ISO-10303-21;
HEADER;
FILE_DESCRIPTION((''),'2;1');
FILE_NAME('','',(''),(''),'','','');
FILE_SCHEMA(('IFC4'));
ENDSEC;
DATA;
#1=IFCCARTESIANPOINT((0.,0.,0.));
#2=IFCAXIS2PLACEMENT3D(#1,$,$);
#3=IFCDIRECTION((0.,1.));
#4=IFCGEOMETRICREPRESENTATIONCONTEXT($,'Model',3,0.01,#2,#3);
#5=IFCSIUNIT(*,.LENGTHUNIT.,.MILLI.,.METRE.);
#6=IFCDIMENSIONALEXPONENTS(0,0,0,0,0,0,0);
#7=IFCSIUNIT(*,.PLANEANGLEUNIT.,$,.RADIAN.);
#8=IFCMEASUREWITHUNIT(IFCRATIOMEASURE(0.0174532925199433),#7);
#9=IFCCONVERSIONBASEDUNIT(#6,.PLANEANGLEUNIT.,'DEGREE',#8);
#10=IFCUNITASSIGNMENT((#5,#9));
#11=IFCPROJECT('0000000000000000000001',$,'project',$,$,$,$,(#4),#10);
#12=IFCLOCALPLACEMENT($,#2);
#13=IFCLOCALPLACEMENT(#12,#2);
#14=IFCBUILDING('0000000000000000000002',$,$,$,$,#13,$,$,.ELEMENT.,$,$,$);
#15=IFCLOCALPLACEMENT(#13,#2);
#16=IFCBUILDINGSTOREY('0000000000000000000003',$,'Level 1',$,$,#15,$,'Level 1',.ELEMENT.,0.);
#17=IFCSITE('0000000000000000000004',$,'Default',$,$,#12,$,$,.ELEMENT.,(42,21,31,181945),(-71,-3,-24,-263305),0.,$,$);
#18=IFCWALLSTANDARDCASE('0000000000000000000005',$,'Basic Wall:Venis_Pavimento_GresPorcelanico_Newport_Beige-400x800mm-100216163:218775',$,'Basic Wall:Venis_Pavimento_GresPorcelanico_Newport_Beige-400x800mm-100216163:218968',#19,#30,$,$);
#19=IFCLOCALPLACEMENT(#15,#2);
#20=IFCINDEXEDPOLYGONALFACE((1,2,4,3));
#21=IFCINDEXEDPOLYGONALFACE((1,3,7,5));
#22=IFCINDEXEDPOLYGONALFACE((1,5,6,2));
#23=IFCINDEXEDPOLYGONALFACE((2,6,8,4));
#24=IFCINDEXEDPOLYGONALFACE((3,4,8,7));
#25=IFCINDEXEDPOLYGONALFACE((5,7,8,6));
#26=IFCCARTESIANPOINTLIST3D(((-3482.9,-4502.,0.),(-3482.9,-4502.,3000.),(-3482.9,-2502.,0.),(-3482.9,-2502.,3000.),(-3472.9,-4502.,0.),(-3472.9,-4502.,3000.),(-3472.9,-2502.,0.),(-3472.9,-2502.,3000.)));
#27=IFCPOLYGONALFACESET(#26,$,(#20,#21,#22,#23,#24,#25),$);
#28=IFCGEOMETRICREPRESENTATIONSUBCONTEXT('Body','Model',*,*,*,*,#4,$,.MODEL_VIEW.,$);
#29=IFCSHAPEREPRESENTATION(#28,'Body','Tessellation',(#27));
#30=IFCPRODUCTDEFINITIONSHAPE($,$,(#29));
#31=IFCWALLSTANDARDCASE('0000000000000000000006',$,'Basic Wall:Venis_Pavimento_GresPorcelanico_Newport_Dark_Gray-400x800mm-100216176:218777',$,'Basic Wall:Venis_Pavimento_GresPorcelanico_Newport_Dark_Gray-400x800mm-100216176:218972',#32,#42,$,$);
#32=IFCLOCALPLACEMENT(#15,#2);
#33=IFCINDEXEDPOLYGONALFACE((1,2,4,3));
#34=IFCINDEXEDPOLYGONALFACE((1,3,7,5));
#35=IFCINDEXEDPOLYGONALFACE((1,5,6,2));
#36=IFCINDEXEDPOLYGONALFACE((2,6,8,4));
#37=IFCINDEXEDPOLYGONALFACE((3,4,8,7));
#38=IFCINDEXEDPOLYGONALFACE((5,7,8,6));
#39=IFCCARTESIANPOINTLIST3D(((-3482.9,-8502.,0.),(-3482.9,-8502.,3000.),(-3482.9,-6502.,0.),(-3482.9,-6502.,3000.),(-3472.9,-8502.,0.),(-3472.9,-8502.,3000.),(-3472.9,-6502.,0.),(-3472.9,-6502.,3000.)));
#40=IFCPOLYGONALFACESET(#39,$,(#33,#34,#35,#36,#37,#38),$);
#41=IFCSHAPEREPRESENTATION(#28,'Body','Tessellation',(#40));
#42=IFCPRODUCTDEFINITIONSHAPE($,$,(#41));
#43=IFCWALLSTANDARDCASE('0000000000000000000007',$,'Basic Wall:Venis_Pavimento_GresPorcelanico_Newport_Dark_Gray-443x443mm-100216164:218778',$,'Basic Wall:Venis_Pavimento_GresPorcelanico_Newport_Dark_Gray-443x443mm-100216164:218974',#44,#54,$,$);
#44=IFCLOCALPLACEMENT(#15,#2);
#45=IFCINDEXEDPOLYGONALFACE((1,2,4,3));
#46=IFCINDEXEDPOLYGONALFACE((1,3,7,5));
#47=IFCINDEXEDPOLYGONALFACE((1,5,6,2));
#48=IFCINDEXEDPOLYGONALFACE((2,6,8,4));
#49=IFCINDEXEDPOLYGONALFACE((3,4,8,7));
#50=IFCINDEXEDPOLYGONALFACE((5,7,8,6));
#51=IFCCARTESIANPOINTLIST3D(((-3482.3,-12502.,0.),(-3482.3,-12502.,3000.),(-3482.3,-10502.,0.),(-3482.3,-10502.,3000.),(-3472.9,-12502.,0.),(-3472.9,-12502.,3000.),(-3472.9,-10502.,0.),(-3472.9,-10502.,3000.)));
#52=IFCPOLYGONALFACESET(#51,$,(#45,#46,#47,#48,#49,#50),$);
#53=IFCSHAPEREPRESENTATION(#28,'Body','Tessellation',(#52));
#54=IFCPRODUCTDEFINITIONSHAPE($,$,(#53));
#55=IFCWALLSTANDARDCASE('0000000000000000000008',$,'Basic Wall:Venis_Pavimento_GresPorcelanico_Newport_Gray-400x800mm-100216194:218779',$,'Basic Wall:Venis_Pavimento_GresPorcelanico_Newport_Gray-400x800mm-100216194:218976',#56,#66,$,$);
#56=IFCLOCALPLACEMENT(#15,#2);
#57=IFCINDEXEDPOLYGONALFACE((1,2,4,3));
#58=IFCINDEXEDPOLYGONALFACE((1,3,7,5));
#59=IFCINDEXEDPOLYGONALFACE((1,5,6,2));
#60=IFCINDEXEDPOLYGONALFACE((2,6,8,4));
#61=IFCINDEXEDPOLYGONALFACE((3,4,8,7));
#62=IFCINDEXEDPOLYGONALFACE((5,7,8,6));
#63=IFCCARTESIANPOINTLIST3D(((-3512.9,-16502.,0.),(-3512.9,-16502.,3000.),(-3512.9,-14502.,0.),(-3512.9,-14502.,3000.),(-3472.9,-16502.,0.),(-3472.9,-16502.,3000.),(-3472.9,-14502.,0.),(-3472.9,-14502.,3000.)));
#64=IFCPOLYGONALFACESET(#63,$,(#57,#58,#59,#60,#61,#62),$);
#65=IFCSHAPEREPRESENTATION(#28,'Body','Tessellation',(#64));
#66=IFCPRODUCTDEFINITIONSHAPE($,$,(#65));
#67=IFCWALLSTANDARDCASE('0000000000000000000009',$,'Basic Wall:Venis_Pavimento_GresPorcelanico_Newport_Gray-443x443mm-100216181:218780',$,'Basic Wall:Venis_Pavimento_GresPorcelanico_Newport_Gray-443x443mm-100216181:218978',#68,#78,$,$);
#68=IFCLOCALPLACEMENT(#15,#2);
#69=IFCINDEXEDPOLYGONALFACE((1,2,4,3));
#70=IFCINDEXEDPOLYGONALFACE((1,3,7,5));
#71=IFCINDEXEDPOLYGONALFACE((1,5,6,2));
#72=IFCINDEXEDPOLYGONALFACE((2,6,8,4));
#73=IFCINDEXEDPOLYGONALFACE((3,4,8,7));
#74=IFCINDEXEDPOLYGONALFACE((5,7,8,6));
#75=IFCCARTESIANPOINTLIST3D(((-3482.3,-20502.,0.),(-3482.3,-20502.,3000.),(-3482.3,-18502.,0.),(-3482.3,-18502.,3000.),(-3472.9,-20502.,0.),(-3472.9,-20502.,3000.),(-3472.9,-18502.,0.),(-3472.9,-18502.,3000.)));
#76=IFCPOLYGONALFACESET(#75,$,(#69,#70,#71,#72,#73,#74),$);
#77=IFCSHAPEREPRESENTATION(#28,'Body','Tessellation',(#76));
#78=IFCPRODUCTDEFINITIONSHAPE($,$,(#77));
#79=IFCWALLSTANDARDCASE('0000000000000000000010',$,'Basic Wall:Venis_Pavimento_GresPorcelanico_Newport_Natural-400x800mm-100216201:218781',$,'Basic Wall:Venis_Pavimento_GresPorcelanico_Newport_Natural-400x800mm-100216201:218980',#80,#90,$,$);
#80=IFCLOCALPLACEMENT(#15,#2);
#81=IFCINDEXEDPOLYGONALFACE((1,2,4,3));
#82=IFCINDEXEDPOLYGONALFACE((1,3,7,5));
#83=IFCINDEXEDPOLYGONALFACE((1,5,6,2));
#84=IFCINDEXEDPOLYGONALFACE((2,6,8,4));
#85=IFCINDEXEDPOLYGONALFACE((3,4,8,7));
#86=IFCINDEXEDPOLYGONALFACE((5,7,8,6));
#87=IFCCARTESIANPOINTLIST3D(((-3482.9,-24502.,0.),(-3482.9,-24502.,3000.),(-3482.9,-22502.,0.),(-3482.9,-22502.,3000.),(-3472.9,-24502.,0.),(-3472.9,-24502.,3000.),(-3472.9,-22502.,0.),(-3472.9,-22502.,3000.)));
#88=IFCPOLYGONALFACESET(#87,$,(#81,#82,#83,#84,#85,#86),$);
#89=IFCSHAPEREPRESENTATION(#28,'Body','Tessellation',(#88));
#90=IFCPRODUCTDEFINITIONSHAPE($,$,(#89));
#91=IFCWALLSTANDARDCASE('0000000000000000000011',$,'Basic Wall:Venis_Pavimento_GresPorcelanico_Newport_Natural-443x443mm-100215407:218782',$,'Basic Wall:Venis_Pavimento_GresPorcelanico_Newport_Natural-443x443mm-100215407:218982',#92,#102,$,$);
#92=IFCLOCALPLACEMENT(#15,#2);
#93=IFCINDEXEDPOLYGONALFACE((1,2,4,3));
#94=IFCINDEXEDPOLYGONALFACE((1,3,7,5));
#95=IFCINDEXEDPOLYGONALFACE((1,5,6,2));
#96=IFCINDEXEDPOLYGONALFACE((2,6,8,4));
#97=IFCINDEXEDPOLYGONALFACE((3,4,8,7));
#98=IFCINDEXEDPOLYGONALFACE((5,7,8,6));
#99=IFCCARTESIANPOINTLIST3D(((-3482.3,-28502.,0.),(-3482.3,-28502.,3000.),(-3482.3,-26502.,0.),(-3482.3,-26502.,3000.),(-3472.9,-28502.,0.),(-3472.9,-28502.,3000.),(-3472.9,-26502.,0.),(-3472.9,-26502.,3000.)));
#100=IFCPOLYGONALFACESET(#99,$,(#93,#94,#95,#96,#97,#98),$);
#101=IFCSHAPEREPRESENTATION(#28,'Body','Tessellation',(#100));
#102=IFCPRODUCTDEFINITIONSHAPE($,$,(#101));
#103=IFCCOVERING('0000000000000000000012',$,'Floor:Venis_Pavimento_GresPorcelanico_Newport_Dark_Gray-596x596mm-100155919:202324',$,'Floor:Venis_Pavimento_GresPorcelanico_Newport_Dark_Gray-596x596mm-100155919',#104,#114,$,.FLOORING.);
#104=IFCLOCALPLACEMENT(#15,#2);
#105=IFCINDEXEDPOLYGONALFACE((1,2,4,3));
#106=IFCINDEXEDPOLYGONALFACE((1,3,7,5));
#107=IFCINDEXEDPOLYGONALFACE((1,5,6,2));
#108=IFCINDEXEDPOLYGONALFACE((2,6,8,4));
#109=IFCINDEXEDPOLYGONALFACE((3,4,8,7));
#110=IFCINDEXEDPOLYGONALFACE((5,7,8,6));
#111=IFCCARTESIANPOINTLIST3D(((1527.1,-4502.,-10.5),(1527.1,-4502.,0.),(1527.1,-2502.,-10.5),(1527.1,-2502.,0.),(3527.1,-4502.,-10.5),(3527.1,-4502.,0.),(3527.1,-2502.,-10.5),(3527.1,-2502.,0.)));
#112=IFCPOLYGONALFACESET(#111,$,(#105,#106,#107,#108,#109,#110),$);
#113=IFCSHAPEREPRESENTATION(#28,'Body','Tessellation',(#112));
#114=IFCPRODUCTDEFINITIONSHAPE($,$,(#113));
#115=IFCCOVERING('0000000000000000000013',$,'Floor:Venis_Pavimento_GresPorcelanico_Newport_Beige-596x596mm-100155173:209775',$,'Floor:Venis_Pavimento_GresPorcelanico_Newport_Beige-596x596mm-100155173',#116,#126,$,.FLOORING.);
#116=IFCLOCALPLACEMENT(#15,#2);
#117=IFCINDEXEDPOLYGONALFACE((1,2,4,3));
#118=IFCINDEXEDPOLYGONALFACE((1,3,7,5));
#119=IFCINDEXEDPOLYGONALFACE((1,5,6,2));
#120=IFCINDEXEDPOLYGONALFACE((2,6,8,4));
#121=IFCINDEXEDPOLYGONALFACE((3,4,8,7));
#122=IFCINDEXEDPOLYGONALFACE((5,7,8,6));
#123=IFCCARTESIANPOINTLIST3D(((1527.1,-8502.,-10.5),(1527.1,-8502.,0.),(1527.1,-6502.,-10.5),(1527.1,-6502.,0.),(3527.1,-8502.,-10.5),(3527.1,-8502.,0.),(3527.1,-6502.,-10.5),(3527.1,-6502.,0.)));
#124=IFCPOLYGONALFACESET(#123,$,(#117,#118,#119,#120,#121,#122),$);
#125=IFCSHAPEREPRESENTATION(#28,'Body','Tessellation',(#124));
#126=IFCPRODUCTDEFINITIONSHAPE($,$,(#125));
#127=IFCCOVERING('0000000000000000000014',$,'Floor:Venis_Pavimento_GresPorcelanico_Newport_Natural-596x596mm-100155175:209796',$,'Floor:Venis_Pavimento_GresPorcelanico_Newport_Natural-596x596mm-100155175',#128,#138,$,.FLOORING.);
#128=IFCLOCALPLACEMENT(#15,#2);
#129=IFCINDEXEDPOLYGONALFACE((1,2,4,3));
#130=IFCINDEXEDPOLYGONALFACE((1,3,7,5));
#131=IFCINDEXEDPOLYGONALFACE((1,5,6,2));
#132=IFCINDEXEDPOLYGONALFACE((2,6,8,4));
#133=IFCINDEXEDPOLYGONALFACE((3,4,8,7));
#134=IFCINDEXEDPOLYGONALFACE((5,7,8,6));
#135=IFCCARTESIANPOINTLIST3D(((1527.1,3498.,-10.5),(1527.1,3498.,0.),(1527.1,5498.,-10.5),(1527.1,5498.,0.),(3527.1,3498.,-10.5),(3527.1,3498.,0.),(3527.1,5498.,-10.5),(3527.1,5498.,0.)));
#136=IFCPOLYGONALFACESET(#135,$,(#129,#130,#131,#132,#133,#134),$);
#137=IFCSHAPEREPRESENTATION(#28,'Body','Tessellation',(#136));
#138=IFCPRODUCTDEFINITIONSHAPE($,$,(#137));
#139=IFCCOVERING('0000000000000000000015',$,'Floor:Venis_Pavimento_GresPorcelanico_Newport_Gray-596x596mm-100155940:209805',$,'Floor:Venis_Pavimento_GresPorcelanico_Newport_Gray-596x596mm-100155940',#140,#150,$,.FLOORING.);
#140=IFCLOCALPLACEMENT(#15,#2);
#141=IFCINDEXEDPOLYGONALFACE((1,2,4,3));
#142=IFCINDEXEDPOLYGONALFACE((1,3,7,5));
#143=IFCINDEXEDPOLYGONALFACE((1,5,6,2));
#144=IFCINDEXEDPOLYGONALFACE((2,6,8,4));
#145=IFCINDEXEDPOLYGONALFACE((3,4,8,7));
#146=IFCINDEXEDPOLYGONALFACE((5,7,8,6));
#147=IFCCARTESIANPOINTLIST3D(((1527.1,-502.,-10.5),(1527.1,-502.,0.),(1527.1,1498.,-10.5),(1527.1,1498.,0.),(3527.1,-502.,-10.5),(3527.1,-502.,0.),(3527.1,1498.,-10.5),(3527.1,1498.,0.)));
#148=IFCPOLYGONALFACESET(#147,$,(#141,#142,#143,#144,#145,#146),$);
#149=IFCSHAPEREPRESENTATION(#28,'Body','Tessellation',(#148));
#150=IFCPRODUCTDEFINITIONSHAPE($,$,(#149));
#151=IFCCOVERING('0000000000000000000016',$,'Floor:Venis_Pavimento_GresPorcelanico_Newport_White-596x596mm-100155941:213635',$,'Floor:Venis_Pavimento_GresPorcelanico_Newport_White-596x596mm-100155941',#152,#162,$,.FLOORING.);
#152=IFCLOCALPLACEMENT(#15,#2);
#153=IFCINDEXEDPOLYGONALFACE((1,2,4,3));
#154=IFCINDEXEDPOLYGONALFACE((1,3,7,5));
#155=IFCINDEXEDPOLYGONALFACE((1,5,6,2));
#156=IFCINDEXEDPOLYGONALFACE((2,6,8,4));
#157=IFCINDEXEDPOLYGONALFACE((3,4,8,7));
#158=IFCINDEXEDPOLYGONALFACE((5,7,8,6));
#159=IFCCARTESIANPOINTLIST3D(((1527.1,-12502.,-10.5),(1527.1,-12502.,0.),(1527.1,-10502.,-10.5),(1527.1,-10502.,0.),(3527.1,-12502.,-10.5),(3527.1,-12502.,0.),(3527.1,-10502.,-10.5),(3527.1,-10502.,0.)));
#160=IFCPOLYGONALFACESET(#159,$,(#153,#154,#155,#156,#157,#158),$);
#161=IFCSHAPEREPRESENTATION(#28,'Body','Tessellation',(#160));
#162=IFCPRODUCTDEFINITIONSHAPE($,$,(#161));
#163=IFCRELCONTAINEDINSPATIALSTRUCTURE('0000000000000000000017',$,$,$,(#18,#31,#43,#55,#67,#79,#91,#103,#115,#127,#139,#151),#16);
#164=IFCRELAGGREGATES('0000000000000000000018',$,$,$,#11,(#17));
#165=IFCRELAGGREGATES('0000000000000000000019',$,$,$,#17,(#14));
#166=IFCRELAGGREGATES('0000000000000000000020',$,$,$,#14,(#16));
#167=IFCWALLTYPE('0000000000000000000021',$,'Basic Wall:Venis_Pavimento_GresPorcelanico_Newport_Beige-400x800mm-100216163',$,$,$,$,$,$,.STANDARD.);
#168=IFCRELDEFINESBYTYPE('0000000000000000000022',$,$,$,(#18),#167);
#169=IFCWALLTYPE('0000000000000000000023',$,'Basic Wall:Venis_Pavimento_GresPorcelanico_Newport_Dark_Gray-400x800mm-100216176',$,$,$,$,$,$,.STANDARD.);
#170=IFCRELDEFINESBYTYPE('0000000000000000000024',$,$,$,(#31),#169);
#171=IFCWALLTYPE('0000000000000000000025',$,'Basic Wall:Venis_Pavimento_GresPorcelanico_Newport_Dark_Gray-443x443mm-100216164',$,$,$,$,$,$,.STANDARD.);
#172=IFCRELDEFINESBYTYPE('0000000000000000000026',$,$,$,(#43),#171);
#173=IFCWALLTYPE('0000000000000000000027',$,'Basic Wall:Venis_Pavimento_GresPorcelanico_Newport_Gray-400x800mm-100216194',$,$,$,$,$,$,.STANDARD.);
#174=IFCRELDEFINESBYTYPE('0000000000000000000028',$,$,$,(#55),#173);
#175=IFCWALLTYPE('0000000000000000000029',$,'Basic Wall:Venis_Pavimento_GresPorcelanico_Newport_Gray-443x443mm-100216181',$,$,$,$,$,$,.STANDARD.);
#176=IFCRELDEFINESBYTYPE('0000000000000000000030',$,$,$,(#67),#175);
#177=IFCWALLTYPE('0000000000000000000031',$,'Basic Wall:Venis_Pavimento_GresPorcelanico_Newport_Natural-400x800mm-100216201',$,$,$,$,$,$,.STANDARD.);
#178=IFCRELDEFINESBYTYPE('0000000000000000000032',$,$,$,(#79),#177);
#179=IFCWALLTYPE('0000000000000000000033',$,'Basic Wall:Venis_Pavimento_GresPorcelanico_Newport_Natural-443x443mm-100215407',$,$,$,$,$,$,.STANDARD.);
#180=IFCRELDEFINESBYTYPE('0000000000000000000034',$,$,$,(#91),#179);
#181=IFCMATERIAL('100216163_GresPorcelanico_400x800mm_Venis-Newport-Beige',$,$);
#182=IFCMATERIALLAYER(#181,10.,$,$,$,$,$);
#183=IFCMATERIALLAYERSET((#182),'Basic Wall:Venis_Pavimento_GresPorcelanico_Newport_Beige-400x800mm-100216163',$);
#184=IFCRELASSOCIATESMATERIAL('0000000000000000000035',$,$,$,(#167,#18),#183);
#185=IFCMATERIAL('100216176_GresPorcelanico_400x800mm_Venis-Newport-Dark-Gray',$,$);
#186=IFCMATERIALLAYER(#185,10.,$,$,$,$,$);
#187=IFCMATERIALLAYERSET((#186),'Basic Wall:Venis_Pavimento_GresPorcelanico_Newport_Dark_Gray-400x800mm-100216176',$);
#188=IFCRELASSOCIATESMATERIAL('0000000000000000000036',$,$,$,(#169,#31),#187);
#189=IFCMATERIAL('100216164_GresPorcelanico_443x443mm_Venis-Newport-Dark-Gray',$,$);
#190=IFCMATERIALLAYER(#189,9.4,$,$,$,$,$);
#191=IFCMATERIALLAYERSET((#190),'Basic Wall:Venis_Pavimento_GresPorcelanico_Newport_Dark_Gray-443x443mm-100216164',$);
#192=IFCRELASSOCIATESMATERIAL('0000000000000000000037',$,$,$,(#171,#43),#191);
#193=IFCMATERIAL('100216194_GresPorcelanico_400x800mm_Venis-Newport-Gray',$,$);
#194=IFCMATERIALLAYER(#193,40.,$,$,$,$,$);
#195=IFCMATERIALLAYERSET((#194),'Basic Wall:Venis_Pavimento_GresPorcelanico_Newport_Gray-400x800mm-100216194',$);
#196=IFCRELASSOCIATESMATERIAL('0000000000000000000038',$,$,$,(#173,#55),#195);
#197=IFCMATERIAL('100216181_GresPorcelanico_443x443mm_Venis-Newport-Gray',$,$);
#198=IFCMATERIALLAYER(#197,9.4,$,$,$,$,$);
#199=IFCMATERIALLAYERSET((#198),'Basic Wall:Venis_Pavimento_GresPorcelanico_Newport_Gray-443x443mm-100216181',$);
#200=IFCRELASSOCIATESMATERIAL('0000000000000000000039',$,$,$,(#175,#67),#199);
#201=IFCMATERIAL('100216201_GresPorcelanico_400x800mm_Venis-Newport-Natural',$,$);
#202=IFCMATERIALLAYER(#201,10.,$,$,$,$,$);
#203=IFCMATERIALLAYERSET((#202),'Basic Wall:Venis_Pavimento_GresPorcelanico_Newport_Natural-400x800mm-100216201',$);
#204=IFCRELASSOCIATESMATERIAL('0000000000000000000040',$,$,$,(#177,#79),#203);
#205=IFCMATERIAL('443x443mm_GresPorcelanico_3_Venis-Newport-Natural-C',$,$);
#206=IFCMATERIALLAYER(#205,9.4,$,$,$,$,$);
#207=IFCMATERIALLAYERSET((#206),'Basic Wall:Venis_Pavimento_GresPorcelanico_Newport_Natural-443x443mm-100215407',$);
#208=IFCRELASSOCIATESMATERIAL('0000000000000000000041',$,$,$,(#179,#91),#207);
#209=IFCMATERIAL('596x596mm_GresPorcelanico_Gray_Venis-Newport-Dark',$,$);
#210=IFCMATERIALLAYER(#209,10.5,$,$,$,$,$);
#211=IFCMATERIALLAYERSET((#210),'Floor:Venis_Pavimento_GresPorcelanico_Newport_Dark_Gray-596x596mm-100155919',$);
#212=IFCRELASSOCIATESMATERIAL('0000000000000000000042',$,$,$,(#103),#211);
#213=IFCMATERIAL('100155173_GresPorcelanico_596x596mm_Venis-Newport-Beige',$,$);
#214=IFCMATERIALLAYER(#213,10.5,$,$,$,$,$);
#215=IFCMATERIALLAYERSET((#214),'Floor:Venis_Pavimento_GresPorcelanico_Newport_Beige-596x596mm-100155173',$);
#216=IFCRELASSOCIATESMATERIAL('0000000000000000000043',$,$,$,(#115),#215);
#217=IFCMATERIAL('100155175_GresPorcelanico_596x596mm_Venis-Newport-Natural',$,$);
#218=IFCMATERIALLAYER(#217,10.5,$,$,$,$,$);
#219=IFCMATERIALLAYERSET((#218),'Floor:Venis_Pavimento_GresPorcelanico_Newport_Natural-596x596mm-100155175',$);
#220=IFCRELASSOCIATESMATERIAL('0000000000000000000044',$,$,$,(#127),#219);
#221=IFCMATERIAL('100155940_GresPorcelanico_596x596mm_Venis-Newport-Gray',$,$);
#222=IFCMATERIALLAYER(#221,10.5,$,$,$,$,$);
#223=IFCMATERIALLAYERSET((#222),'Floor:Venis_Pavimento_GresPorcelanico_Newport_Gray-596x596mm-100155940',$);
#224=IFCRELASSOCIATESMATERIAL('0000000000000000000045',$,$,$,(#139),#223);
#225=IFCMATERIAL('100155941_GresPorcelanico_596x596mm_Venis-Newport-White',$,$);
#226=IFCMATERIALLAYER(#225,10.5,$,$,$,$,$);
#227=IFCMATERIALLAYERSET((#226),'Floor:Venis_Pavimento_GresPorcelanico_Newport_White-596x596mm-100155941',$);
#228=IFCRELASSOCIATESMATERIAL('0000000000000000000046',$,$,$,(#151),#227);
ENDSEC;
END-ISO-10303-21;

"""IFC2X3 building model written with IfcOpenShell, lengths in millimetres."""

from ifc_helpers import new_model, entity, si_unit, converted_unit, direction, frame, frame_2d, origin, place, context, subcontext, project, spatial, rectangle, extrude, material, layer, layer_set, layer_usage, type_object, element, save


model = new_model("IFC2X3")

# Units and contexts
model_context = context("Model", 3, precision=0.01, world=origin(), true_north=direction((0.0, 1.0)))
body_context = subcontext(model_context, "Body", "Model", "MODEL_VIEW")
ifc_project = project(units=[si_unit("LENGTHUNIT", "METRE", prefix="MILLI"), converted_unit("PLANEANGLEUNIT", "DEGREE", entity("IfcRatioMeasure", 0.0174532925199433), si_unit("PLANEANGLEUNIT", "RADIAN"), dimensions=[0, 0, 0, 0, 0, 0, 0])], contexts=[model_context])

# Site, building, storey
site_placement = place(None, origin())
site = spatial("IfcSite", under=ifc_project, at=site_placement, Name="Default", CompositionType="ELEMENT", RefLatitude=(42, 21, 31, 181945), RefLongitude=(-71, -3, -24, -263305), RefElevation=0.0)
building_placement = place(site_placement, origin())
building = spatial("IfcBuilding", under=site, at=building_placement, CompositionType="ELEMENT")
storey_placement = place(building_placement, origin())
storey = spatial("IfcBuildingStorey", under=building, at=storey_placement, Name="Level 1", LongName="Level 1", CompositionType="ELEMENT", Elevation=0.0)

# Walls
ifc_material_1 = material(Name="596x596mm_GresPorcelanico_Gray_Venis-Newport-Dark")
ifc_material_2 = material(Name="100155173_GresPorcelanico_596x596mm_Venis-Newport-Beige")
ifc_material_3 = material(Name="100155941_GresPorcelanico_596x596mm_Venis-Newport-White")
ifc_material_4 = material(Name="100216163_GresPorcelanico_400x800mm_Venis-Newport-Beige")
ifc_layer_1 = layer(ifc_material_4, 10.0)
ifc_layer_set_1 = layer_set([ifc_layer_1], Name="Basic Wall:Venis_Pavimento_GresPorcelanico_Newport_Beige-400x800mm-100216163")
ifc_layer_usage_1 = layer_usage(ifc_layer_set_1, "AXIS2", "POSITIVE", -5.0)
wall_type_1 = type_object("IfcWallType", Name="Basic Wall:Venis_Pavimento_GresPorcelanico_Newport_Beige-400x800mm-100216163", PredefinedType="STANDARD", material=ifc_layer_set_1)
wall_1_placement = place(storey_placement, frame((-3477.9, -2502.0, 0.0), z_axis=(0.0, 0.0, 1.0), x_axis=(0.0, -1.0, 0.0)))
element("IfcWallStandardCase", 1, at=wall_1_placement, inside=storey, type_object=wall_type_1, material=ifc_layer_usage_1, Name="Basic Wall:Venis_Pavimento_GresPorcelanico_Newport_Beige-400x800mm-100216163:218775", ObjectType="Basic Wall:Venis_Pavimento_GresPorcelanico_Newport_Beige-400x800mm-100216163:218968", context=body_context, shape_type="SweptSolid", body=[
    extrude(rectangle(XDim=2000.0, YDim=10.0, at=frame_2d((1000.0, 0.0), x_axis=(-1.0, 0.0))), origin(), (0.0, 0.0, 1.0), 3000.0),
])
ifc_material_5 = material(Name="100216176_GresPorcelanico_400x800mm_Venis-Newport-Dark-Gray")
ifc_layer_2 = layer(ifc_material_5, 10.0)
ifc_layer_set_2 = layer_set([ifc_layer_2], Name="Basic Wall:Venis_Pavimento_GresPorcelanico_Newport_Dark_Gray-400x800mm-100216176")
ifc_layer_usage_2 = layer_usage(ifc_layer_set_2, "AXIS2", "POSITIVE", -5.0)
wall_type_2 = type_object("IfcWallType", Name="Basic Wall:Venis_Pavimento_GresPorcelanico_Newport_Dark_Gray-400x800mm-100216176", PredefinedType="STANDARD", material=ifc_layer_set_2)
wall_2_placement = place(storey_placement, frame((-3477.9, -6502.0, 0.0), z_axis=(0.0, 0.0, 1.0), x_axis=(0.0, -1.0, 0.0)))
element("IfcWallStandardCase", 2, at=wall_2_placement, inside=storey, type_object=wall_type_2, material=ifc_layer_usage_2, Name="Basic Wall:Venis_Pavimento_GresPorcelanico_Newport_Dark_Gray-400x800mm-100216176:218777", ObjectType="Basic Wall:Venis_Pavimento_GresPorcelanico_Newport_Dark_Gray-400x800mm-100216176:218972", context=body_context, shape_type="SweptSolid", body=[
    extrude(rectangle(XDim=2000.0, YDim=10.0, at=frame_2d((1000.0, 0.0), x_axis=(-1.0, 0.0))), origin(), (0.0, 0.0, 1.0), 3000.0),
])
ifc_material_6 = material(Name="100216164_GresPorcelanico_443x443mm_Venis-Newport-Dark-Gray")
ifc_layer_3 = layer(ifc_material_6, 9.4)
ifc_layer_set_3 = layer_set([ifc_layer_3], Name="Basic Wall:Venis_Pavimento_GresPorcelanico_Newport_Dark_Gray-443x443mm-100216164")
ifc_layer_usage_3 = layer_usage(ifc_layer_set_3, "AXIS2", "POSITIVE", -4.7)
wall_type_3 = type_object("IfcWallType", Name="Basic Wall:Venis_Pavimento_GresPorcelanico_Newport_Dark_Gray-443x443mm-100216164", PredefinedType="STANDARD", material=ifc_layer_set_3)
wall_3_placement = place(storey_placement, frame((-3477.6, -10502.0, 0.0), z_axis=(0.0, 0.0, 1.0), x_axis=(0.0, -1.0, 0.0)))
element("IfcWallStandardCase", 3, at=wall_3_placement, inside=storey, type_object=wall_type_3, material=ifc_layer_usage_3, Name="Basic Wall:Venis_Pavimento_GresPorcelanico_Newport_Dark_Gray-443x443mm-100216164:218778", ObjectType="Basic Wall:Venis_Pavimento_GresPorcelanico_Newport_Dark_Gray-443x443mm-100216164:218974", context=body_context, shape_type="SweptSolid", body=[
    extrude(rectangle(XDim=2000.0, YDim=9.4, at=frame_2d((1000.0, 0.0), x_axis=(-1.0, 0.0))), origin(), (0.0, 0.0, 1.0), 3000.0),
])
ifc_material_7 = material(Name="100216194_GresPorcelanico_400x800mm_Venis-Newport-Gray")
ifc_layer_4 = layer(ifc_material_7, 40.0)
ifc_layer_set_4 = layer_set([ifc_layer_4], Name="Basic Wall:Venis_Pavimento_GresPorcelanico_Newport_Gray-400x800mm-100216194")
ifc_layer_usage_4 = layer_usage(ifc_layer_set_4, "AXIS2", "POSITIVE", -20.0)
wall_type_4 = type_object("IfcWallType", Name="Basic Wall:Venis_Pavimento_GresPorcelanico_Newport_Gray-400x800mm-100216194", PredefinedType="STANDARD", material=ifc_layer_set_4)
wall_4_placement = place(storey_placement, frame((-3492.9, -14502.0, 0.0), z_axis=(0.0, 0.0, 1.0), x_axis=(0.0, -1.0, 0.0)))
element("IfcWallStandardCase", 4, at=wall_4_placement, inside=storey, type_object=wall_type_4, material=ifc_layer_usage_4, Name="Basic Wall:Venis_Pavimento_GresPorcelanico_Newport_Gray-400x800mm-100216194:218779", ObjectType="Basic Wall:Venis_Pavimento_GresPorcelanico_Newport_Gray-400x800mm-100216194:218976", context=body_context, shape_type="SweptSolid", body=[
    extrude(rectangle(XDim=2000.0, YDim=40.0, at=frame_2d((1000.0, 0.0), x_axis=(-1.0, 0.0))), origin(), (0.0, 0.0, 1.0), 3000.0),
])
ifc_material_8 = material(Name="100216181_GresPorcelanico_443x443mm_Venis-Newport-Gray")
ifc_layer_5 = layer(ifc_material_8, 9.4)
ifc_layer_set_5 = layer_set([ifc_layer_5], Name="Basic Wall:Venis_Pavimento_GresPorcelanico_Newport_Gray-443x443mm-100216181")
ifc_layer_usage_5 = layer_usage(ifc_layer_set_5, "AXIS2", "POSITIVE", -4.7)
wall_type_5 = type_object("IfcWallType", Name="Basic Wall:Venis_Pavimento_GresPorcelanico_Newport_Gray-443x443mm-100216181", PredefinedType="STANDARD", material=ifc_layer_set_5)
wall_5_placement = place(storey_placement, frame((-3477.6, -18502.0, 0.0), z_axis=(0.0, 0.0, 1.0), x_axis=(0.0, -1.0, 0.0)))
element("IfcWallStandardCase", 5, at=wall_5_placement, inside=storey, type_object=wall_type_5, material=ifc_layer_usage_5, Name="Basic Wall:Venis_Pavimento_GresPorcelanico_Newport_Gray-443x443mm-100216181:218780", ObjectType="Basic Wall:Venis_Pavimento_GresPorcelanico_Newport_Gray-443x443mm-100216181:218978", context=body_context, shape_type="SweptSolid", body=[
    extrude(rectangle(XDim=2000.0, YDim=9.4, at=frame_2d((1000.0, 0.0), x_axis=(-1.0, 0.0))), origin(), (0.0, 0.0, 1.0), 3000.0),
])
ifc_material_9 = material(Name="100216201_GresPorcelanico_400x800mm_Venis-Newport-Natural")
ifc_layer_6 = layer(ifc_material_9, 10.0)
ifc_layer_set_6 = layer_set([ifc_layer_6], Name="Basic Wall:Venis_Pavimento_GresPorcelanico_Newport_Natural-400x800mm-100216201")
ifc_layer_usage_6 = layer_usage(ifc_layer_set_6, "AXIS2", "POSITIVE", -5.0)
wall_type_6 = type_object("IfcWallType", Name="Basic Wall:Venis_Pavimento_GresPorcelanico_Newport_Natural-400x800mm-100216201", PredefinedType="STANDARD", material=ifc_layer_set_6)
wall_6_placement = place(storey_placement, frame((-3477.9, -22502.0, 0.0), z_axis=(0.0, 0.0, 1.0), x_axis=(0.0, -1.0, 0.0)))
element("IfcWallStandardCase", 6, at=wall_6_placement, inside=storey, type_object=wall_type_6, material=ifc_layer_usage_6, Name="Basic Wall:Venis_Pavimento_GresPorcelanico_Newport_Natural-400x800mm-100216201:218781", ObjectType="Basic Wall:Venis_Pavimento_GresPorcelanico_Newport_Natural-400x800mm-100216201:218980", context=body_context, shape_type="SweptSolid", body=[
    extrude(rectangle(XDim=2000.0, YDim=10.0, at=frame_2d((1000.0, 0.0), x_axis=(-1.0, 0.0))), origin(), (0.0, 0.0, 1.0), 3000.0),
])
ifc_material_10 = material(Name="443x443mm_GresPorcelanico_3_Venis-Newport-Natural-C")
ifc_layer_7 = layer(ifc_material_10, 9.4)
ifc_layer_set_7 = layer_set([ifc_layer_7], Name="Basic Wall:Venis_Pavimento_GresPorcelanico_Newport_Natural-443x443mm-100215407")
ifc_layer_usage_7 = layer_usage(ifc_layer_set_7, "AXIS2", "POSITIVE", -4.7)
wall_type_7 = type_object("IfcWallType", Name="Basic Wall:Venis_Pavimento_GresPorcelanico_Newport_Natural-443x443mm-100215407", PredefinedType="STANDARD", material=ifc_layer_set_7)
wall_7_placement = place(storey_placement, frame((-3477.6, -26502.0, 0.0), z_axis=(0.0, 0.0, 1.0), x_axis=(0.0, -1.0, 0.0)))
element("IfcWallStandardCase", 7, at=wall_7_placement, inside=storey, type_object=wall_type_7, material=ifc_layer_usage_7, Name="Basic Wall:Venis_Pavimento_GresPorcelanico_Newport_Natural-443x443mm-100215407:218782", ObjectType="Basic Wall:Venis_Pavimento_GresPorcelanico_Newport_Natural-443x443mm-100215407:218982", context=body_context, shape_type="SweptSolid", body=[
    extrude(rectangle(XDim=2000.0, YDim=9.4, at=frame_2d((1000.0, 0.0), x_axis=(-1.0, 0.0))), origin(), (0.0, 0.0, 1.0), 3000.0),
])

# Coverings
ifc_layer_8 = layer(ifc_material_1, 10.5)
ifc_layer_set_8 = layer_set([ifc_layer_8], Name="Floor:Venis_Pavimento_GresPorcelanico_Newport_Dark_Gray-596x596mm-100155919")
ifc_layer_usage_8 = layer_usage(ifc_layer_set_8, "AXIS3", "POSITIVE", 0.0)
covering_1_placement = place(storey_placement, origin())
element("IfcCovering", 8, at=covering_1_placement, inside=storey, material=ifc_layer_usage_8, Name="Floor:Venis_Pavimento_GresPorcelanico_Newport_Dark_Gray-596x596mm-100155919:202324", ObjectType="Floor:Venis_Pavimento_GresPorcelanico_Newport_Dark_Gray-596x596mm-100155919", PredefinedType="FLOORING", context=body_context, shape_type="SweptSolid", body=[
    extrude(rectangle(XDim=2000.0, YDim=2000.0, at=frame_2d((0.0, 0.0), x_axis=(1.0, 0.0))), frame((2527.1, -3502.0, 0.0), z_axis=(0.0, 0.0, -1.0), x_axis=(0.0, 1.0, 0.0)), (0.0, 0.0, 1.0), 10.5),
])
ifc_layer_9 = layer(ifc_material_2, 10.5)
ifc_layer_set_9 = layer_set([ifc_layer_9], Name="Floor:Venis_Pavimento_GresPorcelanico_Newport_Beige-596x596mm-100155173")
ifc_layer_usage_9 = layer_usage(ifc_layer_set_9, "AXIS3", "POSITIVE", 0.0)
covering_2_placement = place(storey_placement, origin())
element("IfcCovering", 9, at=covering_2_placement, inside=storey, material=ifc_layer_usage_9, Name="Floor:Venis_Pavimento_GresPorcelanico_Newport_Beige-596x596mm-100155173:209775", ObjectType="Floor:Venis_Pavimento_GresPorcelanico_Newport_Beige-596x596mm-100155173", PredefinedType="FLOORING", context=body_context, shape_type="SweptSolid", body=[
    extrude(rectangle(XDim=2000.0, YDim=2000.0, at=frame_2d((0.0, 0.0), x_axis=(1.0, 0.0))), frame((2527.1, -7502.0, 0.0), z_axis=(0.0, 0.0, -1.0), x_axis=(0.0, 1.0, 0.0)), (0.0, 0.0, 1.0), 10.5),
])
ifc_material_11 = material(Name="100155175_GresPorcelanico_596x596mm_Venis-Newport-Natural")
ifc_layer_10 = layer(ifc_material_11, 10.5)
ifc_layer_set_10 = layer_set([ifc_layer_10], Name="Floor:Venis_Pavimento_GresPorcelanico_Newport_Natural-596x596mm-100155175")
ifc_layer_usage_10 = layer_usage(ifc_layer_set_10, "AXIS3", "POSITIVE", 0.0)
covering_3_placement = place(storey_placement, origin())
element("IfcCovering", 10, at=covering_3_placement, inside=storey, material=ifc_layer_usage_10, Name="Floor:Venis_Pavimento_GresPorcelanico_Newport_Natural-596x596mm-100155175:209796", ObjectType="Floor:Venis_Pavimento_GresPorcelanico_Newport_Natural-596x596mm-100155175", PredefinedType="FLOORING", context=body_context, shape_type="SweptSolid", body=[
    extrude(rectangle(XDim=2000.0, YDim=2000.0, at=frame_2d((0.0, 0.0), x_axis=(1.0, 0.0))), frame((2527.1, 4498.0, 0.0), z_axis=(0.0, 0.0, -1.0), x_axis=(0.0, 1.0, 0.0)), (0.0, 0.0, 1.0), 10.5),
])
ifc_material_12 = material(Name="100155940_GresPorcelanico_596x596mm_Venis-Newport-Gray")
ifc_layer_11 = layer(ifc_material_12, 10.5)
ifc_layer_set_11 = layer_set([ifc_layer_11], Name="Floor:Venis_Pavimento_GresPorcelanico_Newport_Gray-596x596mm-100155940")
ifc_layer_usage_11 = layer_usage(ifc_layer_set_11, "AXIS3", "POSITIVE", 0.0)
covering_4_placement = place(storey_placement, origin())
element("IfcCovering", 11, at=covering_4_placement, inside=storey, material=ifc_layer_usage_11, Name="Floor:Venis_Pavimento_GresPorcelanico_Newport_Gray-596x596mm-100155940:209805", ObjectType="Floor:Venis_Pavimento_GresPorcelanico_Newport_Gray-596x596mm-100155940", PredefinedType="FLOORING", context=body_context, shape_type="SweptSolid", body=[
    extrude(rectangle(XDim=2000.0, YDim=2000.0, at=frame_2d((0.0, 0.0), x_axis=(1.0, 0.0))), frame((2527.1, 498.0, 0.0), z_axis=(0.0, 0.0, -1.0), x_axis=(0.0, 1.0, 0.0)), (0.0, 0.0, 1.0), 10.5),
])
ifc_layer_12 = layer(ifc_material_3, 10.5)
ifc_layer_set_12 = layer_set([ifc_layer_12], Name="Floor:Venis_Pavimento_GresPorcelanico_Newport_White-596x596mm-100155941")
ifc_layer_usage_12 = layer_usage(ifc_layer_set_12, "AXIS3", "POSITIVE", 0.0)
covering_5_placement = place(storey_placement, origin())
element("IfcCovering", 12, at=covering_5_placement, inside=storey, material=ifc_layer_usage_12, Name="Floor:Venis_Pavimento_GresPorcelanico_Newport_White-596x596mm-100155941:213635", ObjectType="Floor:Venis_Pavimento_GresPorcelanico_Newport_White-596x596mm-100155941", PredefinedType="FLOORING", context=body_context, shape_type="SweptSolid", body=[
    extrude(rectangle(XDim=2000.0, YDim=2000.0, at=frame_2d((0.0, 0.0), x_axis=(1.0, 0.0))), frame((2527.1, -11502.0, 0.0), z_axis=(0.0, 0.0, -1.0), x_axis=(0.0, 1.0, 0.0)), (0.0, 0.0, 1.0), 10.5),
])

save(model, "model.ifc")
